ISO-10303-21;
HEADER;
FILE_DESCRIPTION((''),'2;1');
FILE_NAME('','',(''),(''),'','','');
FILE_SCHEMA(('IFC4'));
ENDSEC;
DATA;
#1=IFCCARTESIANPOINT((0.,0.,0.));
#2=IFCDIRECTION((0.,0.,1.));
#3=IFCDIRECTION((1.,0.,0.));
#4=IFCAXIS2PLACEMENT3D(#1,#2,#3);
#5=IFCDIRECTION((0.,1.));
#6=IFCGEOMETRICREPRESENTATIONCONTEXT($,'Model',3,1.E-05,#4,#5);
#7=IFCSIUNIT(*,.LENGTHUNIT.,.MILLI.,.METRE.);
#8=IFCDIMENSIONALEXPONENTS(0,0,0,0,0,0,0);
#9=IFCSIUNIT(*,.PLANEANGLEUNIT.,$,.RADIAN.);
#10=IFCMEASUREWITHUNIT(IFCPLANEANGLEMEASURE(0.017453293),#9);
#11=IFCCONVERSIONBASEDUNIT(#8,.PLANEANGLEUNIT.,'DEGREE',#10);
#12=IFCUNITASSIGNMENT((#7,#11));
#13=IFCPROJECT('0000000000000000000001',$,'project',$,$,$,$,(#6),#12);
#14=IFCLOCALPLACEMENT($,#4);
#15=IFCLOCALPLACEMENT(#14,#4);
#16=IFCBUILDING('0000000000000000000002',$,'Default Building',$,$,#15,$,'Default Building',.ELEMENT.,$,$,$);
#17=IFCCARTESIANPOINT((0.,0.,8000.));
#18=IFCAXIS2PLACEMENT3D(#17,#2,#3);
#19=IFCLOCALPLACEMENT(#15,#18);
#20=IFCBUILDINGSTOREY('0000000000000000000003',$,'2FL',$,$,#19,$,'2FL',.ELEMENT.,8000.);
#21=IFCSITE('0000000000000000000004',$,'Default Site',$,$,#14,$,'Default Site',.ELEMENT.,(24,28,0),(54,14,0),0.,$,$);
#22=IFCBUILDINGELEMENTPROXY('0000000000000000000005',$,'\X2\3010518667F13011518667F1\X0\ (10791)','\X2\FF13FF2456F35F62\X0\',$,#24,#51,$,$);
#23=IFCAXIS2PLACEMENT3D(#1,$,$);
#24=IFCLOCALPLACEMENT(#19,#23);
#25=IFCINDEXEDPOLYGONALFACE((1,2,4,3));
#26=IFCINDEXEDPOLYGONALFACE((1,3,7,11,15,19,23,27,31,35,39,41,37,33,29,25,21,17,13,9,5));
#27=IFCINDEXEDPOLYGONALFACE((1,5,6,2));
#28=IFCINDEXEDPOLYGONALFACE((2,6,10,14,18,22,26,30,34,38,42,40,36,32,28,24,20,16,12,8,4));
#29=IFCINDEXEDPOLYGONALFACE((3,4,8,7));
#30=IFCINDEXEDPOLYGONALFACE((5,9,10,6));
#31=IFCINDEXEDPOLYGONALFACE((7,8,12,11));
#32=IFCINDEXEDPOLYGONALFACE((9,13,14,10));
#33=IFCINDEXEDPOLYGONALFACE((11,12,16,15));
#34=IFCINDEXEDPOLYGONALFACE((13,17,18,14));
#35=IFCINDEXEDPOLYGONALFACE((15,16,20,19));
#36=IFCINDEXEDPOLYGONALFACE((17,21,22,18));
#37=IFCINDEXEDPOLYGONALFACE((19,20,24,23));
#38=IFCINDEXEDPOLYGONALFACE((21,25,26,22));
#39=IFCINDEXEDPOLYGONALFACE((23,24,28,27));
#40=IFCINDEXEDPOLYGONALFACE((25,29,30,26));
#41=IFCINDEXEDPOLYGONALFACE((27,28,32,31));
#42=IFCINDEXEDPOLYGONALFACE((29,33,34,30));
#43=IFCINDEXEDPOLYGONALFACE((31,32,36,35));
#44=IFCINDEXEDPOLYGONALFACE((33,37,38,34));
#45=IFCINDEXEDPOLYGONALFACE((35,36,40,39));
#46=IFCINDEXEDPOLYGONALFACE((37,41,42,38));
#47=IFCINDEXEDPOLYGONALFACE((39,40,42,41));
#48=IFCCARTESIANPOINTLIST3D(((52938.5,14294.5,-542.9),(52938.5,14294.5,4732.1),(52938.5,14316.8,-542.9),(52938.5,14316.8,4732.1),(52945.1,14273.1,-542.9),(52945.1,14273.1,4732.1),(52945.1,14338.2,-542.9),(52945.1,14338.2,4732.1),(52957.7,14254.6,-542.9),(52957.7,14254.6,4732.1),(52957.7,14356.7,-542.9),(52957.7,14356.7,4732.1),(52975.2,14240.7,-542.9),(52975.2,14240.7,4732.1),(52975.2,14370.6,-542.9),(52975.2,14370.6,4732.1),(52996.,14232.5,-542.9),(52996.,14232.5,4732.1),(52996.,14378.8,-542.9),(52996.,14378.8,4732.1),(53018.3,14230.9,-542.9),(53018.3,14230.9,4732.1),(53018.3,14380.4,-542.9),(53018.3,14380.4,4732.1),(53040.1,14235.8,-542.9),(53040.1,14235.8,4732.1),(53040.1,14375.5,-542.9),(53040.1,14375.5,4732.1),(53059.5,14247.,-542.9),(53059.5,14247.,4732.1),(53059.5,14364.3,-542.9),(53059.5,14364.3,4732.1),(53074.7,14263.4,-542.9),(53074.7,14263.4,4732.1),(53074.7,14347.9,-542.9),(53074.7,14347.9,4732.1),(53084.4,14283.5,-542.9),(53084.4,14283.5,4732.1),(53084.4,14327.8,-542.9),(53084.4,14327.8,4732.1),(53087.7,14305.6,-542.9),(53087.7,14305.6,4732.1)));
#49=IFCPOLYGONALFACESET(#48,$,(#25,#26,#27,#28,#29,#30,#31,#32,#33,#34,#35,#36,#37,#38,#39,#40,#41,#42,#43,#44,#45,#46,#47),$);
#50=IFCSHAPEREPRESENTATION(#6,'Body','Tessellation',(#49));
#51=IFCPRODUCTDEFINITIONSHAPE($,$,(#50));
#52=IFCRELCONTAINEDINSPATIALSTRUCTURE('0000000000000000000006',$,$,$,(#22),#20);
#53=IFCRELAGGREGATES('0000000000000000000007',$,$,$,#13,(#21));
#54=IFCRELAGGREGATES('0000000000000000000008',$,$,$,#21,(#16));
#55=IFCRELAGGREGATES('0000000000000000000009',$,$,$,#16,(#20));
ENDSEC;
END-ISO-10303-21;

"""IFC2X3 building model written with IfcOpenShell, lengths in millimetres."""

from ifc_helpers import new_model, entity, si_unit, converted_unit, direction, frame, origin_with_axes, origin_2d_with_axis, place, context, project, spatial, circle, extrude, source, transform, mapped, element, save


model = new_model("IFC2X3")

# Units and contexts
model_context = context("Model", 3, precision=1e-05, world=origin_with_axes(), true_north=direction((0.0, 1.0)))
ifc_project = project(units=[si_unit("LENGTHUNIT", "METRE", prefix="MILLI"), converted_unit("PLANEANGLEUNIT", "DEGREE", entity("IfcPlaneAngleMeasure", 0.017453293), si_unit("PLANEANGLEUNIT", "RADIAN"), dimensions=[0, 0, 0, 0, 0, 0, 0])], contexts=[model_context])

# Site, building, storey
site_placement = place(None, origin_with_axes())
site = spatial("IfcSite", under=ifc_project, at=site_placement, Name="Default Site", LongName="Default Site", CompositionType="ELEMENT", RefLatitude=(24, 28, 0), RefLongitude=(54, 14, 0), RefElevation=0.0)
building_placement = place(site_placement, origin_with_axes())
building = spatial("IfcBuilding", under=site, at=building_placement, Name="Default Building", LongName="Default Building", CompositionType="ELEMENT")
storey_placement = place(building_placement, frame((0.0, 0.0, 8000.0), z_axis=(0.0, 0.0, 1.0), x_axis=(1.0, 0.0, 0.0)))
storey = spatial("IfcBuildingStorey", under=building, at=storey_placement, Name="2FL", LongName="2FL", CompositionType="ELEMENT", Elevation=8000.0)

# Building element proxy
shared_shape_1 = source(origin_with_axes(), model_context, "Body", "SweptSolid", [
    extrude(circle(Radius=75.0, at=origin_2d_with_axis()), origin_with_axes(), (0.0, 0.0, 1.0), 5275.0),
])
proxy_1_placement = place(storey_placement, frame((53012.7, 14305.6, -542.9), z_axis=(0.0, 0.0, 1.0), x_axis=(1.0, 0.0, 0.0)))
element("IfcBuildingElementProxy", 1, at=proxy_1_placement, inside=storey, Name="【円柱】円柱 (10791)", Description="３Ｄ図形", context=model_context, shape_type="MappedRepresentation", body=[
    mapped(shared_shape_1, transform((0.0, 0.0, 0.0))),
])

save(model, "model.ifc")
